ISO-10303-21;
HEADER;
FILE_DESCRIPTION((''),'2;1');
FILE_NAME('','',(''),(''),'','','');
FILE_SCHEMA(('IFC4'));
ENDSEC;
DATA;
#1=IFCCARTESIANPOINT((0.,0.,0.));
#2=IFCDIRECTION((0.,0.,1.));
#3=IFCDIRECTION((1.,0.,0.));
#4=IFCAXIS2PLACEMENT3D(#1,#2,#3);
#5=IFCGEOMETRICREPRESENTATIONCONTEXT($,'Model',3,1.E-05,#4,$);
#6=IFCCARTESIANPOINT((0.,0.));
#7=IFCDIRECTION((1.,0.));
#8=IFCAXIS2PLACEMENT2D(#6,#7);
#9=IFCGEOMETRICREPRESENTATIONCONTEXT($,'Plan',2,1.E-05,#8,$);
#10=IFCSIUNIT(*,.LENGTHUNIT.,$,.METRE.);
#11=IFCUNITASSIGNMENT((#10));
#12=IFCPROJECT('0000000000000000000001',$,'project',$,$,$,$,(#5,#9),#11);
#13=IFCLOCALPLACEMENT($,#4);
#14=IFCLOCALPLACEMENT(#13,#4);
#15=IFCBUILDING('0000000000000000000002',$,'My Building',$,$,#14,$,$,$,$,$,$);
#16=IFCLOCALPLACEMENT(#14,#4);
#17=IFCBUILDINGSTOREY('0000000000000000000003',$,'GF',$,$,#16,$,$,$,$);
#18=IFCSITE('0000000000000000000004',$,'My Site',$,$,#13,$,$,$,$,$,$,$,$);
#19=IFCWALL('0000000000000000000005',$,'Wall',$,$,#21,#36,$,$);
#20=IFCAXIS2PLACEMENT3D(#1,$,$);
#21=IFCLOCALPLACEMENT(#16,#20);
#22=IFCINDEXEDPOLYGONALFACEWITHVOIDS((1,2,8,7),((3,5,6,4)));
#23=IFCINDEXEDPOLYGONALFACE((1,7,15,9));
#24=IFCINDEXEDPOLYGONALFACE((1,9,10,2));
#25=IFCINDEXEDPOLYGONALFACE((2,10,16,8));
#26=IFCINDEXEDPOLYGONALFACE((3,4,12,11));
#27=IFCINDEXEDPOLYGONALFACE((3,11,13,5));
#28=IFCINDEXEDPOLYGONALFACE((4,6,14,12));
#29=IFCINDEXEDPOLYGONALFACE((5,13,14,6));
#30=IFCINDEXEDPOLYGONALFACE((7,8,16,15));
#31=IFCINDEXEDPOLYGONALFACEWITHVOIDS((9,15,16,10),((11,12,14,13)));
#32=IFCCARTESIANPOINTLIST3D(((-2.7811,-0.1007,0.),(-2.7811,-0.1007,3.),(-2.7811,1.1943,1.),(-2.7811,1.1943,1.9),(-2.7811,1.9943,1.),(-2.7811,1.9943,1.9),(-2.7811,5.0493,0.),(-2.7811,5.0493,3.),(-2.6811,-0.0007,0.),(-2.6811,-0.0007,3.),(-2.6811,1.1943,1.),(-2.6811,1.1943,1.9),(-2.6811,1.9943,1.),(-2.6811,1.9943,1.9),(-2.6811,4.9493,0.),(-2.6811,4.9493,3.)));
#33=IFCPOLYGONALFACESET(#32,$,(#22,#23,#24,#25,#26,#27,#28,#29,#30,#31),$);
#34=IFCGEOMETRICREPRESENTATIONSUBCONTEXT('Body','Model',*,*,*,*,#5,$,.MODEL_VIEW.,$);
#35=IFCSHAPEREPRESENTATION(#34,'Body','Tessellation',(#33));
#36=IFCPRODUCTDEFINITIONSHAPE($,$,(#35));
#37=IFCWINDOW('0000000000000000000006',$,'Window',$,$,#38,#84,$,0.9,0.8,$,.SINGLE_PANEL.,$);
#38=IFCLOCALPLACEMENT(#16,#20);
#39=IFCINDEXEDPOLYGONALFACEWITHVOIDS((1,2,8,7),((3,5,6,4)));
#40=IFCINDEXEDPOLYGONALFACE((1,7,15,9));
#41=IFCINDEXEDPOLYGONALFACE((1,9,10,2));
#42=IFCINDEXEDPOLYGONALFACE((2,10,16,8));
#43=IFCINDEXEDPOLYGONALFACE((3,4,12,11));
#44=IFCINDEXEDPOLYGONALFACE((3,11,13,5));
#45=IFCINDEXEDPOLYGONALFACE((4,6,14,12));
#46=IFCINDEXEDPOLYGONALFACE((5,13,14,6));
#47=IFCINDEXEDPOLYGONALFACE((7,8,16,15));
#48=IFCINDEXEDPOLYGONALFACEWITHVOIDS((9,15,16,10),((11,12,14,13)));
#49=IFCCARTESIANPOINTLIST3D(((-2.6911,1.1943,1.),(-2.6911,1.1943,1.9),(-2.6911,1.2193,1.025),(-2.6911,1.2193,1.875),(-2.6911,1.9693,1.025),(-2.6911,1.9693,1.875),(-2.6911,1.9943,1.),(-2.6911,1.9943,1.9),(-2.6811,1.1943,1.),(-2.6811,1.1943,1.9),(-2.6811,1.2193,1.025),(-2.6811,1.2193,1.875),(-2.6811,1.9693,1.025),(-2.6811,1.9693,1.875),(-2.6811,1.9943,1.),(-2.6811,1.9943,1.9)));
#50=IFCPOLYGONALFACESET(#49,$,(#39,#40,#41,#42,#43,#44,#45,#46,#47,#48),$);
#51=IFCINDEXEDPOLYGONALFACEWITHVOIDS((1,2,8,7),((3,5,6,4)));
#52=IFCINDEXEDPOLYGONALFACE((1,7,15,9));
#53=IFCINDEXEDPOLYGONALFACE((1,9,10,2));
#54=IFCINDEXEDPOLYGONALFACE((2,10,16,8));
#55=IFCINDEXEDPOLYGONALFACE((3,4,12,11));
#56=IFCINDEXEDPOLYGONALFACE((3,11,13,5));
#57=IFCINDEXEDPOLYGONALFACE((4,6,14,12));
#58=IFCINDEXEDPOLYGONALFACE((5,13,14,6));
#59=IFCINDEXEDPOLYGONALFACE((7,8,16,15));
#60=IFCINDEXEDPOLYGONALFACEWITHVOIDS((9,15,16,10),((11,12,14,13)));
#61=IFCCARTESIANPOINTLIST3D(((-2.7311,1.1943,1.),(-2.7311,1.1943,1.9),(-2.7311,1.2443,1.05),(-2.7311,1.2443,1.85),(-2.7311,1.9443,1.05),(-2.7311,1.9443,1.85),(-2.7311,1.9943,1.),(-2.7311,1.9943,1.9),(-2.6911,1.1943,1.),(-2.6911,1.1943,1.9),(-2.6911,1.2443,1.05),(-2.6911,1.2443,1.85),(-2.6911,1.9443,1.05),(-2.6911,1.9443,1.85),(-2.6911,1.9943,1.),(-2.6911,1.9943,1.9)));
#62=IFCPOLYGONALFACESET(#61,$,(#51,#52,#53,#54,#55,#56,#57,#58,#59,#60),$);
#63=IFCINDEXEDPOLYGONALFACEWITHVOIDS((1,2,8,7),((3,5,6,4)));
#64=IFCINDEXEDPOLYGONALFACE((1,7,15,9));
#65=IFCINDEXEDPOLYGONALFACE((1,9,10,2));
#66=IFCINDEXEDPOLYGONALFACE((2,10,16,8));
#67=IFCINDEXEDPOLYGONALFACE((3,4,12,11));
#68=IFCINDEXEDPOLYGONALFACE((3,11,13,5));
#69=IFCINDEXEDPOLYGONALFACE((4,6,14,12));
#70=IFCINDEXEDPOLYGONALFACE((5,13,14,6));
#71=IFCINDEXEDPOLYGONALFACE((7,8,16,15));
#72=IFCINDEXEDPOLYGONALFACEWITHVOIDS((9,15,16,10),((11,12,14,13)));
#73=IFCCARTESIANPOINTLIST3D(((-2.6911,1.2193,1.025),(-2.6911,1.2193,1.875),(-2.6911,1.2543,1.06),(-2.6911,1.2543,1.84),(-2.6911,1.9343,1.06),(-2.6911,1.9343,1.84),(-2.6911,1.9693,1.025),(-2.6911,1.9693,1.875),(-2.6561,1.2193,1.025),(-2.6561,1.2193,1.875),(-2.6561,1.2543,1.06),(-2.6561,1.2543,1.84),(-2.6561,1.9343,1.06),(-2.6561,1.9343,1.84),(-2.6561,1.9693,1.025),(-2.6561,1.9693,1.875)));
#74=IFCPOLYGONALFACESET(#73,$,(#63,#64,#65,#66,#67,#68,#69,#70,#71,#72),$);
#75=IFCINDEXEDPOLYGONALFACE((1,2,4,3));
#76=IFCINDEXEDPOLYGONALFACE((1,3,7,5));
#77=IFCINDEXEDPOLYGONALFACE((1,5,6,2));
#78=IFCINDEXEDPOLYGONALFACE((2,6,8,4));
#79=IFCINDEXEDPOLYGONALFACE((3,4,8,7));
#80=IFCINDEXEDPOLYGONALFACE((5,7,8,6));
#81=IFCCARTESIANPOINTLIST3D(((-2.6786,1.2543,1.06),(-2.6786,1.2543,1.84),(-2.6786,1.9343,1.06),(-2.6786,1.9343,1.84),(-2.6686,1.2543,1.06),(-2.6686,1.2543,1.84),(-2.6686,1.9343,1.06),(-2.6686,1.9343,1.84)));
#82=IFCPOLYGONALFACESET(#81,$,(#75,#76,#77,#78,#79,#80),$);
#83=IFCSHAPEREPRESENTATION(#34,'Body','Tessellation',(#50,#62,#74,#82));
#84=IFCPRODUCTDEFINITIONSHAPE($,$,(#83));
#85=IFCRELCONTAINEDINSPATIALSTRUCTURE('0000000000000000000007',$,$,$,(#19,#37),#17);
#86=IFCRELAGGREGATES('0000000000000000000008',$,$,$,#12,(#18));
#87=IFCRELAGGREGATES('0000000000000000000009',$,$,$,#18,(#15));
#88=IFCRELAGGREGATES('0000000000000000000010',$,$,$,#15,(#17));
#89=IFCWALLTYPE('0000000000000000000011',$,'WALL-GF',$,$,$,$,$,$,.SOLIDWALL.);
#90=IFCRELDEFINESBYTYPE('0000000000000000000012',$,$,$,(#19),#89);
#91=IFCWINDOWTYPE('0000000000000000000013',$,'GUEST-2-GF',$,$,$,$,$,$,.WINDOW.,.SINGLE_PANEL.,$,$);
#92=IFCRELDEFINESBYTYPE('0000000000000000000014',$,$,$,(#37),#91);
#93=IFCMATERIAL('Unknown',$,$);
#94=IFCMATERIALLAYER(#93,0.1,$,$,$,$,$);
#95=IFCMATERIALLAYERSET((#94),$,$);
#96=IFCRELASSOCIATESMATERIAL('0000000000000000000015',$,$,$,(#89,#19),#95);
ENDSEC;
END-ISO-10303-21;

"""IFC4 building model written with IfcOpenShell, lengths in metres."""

from ifc_helpers import new_model, entity, si_unit, frame, origin_with_axes, origin_2d_with_axis, place, context, subcontext, project, spatial, line, indexed_curve, outline, extrude, shape, source, transform, mapped, material, layer, layer_set, layer_usage, type_object, type_shapes, element, fill, save


model = new_model("IFC4")

# Units and contexts
model_context = context("Model", 3, precision=1e-05, world=origin_with_axes())
plan_context = context("Plan", 2, precision=1e-05, world=origin_2d_with_axis())
body_context_1 = subcontext(model_context, "Body", "Model", "MODEL_VIEW")
body_context_2 = subcontext(plan_context, "Body", "Plan", "PLAN_VIEW")
ifc_project = project(units=[si_unit("LENGTHUNIT", "METRE")], contexts=[model_context, plan_context])

# Site, building, storey
site_placement = place(None, origin_with_axes())
site = spatial("IfcSite", under=ifc_project, at=site_placement, Name="My Site")
building_placement = place(site_placement, origin_with_axes())
building = spatial("IfcBuilding", under=site, at=building_placement, Name="My Building")
storey_placement = place(building_placement, origin_with_axes())
storey = spatial("IfcBuildingStorey", under=building, at=storey_placement, Name="GF")

# Shared definitions
ifc_material_1 = material(Name="Unknown")

# Shared definitions
ifc_layer_1 = layer(ifc_material_1, 0.1)
ifc_layer_set_1 = layer_set([ifc_layer_1])
wall_type = type_object("IfcWallType", Name="WALL-GF", PredefinedType="SOLIDWALL", material=ifc_layer_set_1)

# Wall, opening, window
ifc_layer_usage_1 = layer_usage(ifc_layer_set_1, "AXIS2", "POSITIVE", 0.0)
wall_1_placement = place(storey_placement, frame((-2.7811, 5.0493, 0.0), z_axis=(0.0, 0.0, 1.0), x_axis=(0.0, -1.0, 0.0)))
wall_1 = element("IfcWall", 1, at=wall_1_placement, inside=storey, type_object=wall_type, material=ifc_layer_usage_1, Name="Wall", context=body_context_1, shape_type="SweptSolid", body=[
    extrude(outline(indexed_curve([(0.0, 0.0), (0.1, 0.1), (5.05, 0.1), (5.15, 0.0)], segments=[line(1, 2, 3, 4, 1)])), origin_with_axes(), (0.0, 0.0, 1.0), 3.0),
])
shared_shape_1 = source(origin_with_axes(), body_context_1, "Body", "SweptSolid", [
    extrude(outline(indexed_curve([(0.0, 0.0), (0.8, 0.0), (0.8, 0.9), (0.0, 0.9)], segments=[line(1, 2, 3, 4, 1)])), frame((0.0, -0.6, 0.0), z_axis=(0.0, -1.0, 0.0), x_axis=(1.0, 0.0, 0.0)), (0.0, 0.0, -1.0), 1.2),
])
opening_1_placement = place(wall_1_placement, frame((3.0549, 0.0, 1.0), z_axis=(0.0, 0.0, 1.0), x_axis=(1.0, 0.0, 0.0)))
opening_1 = element("IfcOpeningElement", 2, at=opening_1_placement, cuts=wall_1, PredefinedType="OPENING", context=body_context_1, shape_type="MappedRepresentation", body=[
    mapped(shared_shape_1, transform((0.0, 0.0, 0.0), x_axis=(1.0, 0.0, 0.0), y_axis=(0.0, 1.0, 0.0), z_axis=(0.0, 0.0, 1.0), scale=1.0)),
])
window_type_1 = type_object("IfcWindowType", Name="GUEST-2-GF", PartitioningType="SINGLE_PANEL", PredefinedType="WINDOW")
shared_shape_2 = source(origin_with_axes(), body_context_1, "Body", "SweptSolid", [
    extrude(outline(indexed_curve([(0.0, 0.0), (0.8, 0.0), (0.8, 0.9), (0.0, 0.9)], segments=[line(1, 2, 3, 4, 1)]), holes=[indexed_curve([(0.025, 0.025), (0.775, 0.025), (0.775, 0.875), (0.025, 0.875)], segments=[line(1, 2, 3, 4, 1)])]), frame((0.0, 0.09, 0.0), z_axis=(0.0, -1.0, 0.0), x_axis=(1.0, 0.0, 0.0)), (0.0, 0.0, -1.0), 0.01),
    extrude(outline(indexed_curve([(0.0, 0.0), (0.8, 0.0), (0.8, 0.9), (0.0, 0.9)], segments=[line(1, 2, 3, 4, 1)]), holes=[indexed_curve([(0.05, 0.05), (0.75, 0.05), (0.75, 0.85), (0.05, 0.85)], segments=[line(1, 2, 3, 4, 1)])]), frame((0.0, 0.05, 0.0), z_axis=(0.0, -1.0, 0.0), x_axis=(1.0, 0.0, 0.0)), (0.0, 0.0, -1.0), 0.04),
    extrude(outline(indexed_curve([(0.0, 0.0), (0.75, 0.0), (0.75, 0.85), (0.0, 0.85)], segments=[line(1, 2, 3, 4, 1)]), holes=[indexed_curve([(0.035, 0.035), (0.715, 0.035), (0.715, 0.815), (0.035, 0.815)], segments=[line(1, 2, 3, 4, 1)])]), frame((0.025, 0.09, 0.025), z_axis=(0.0, -1.0, 0.0), x_axis=(1.0, 0.0, 0.0)), (0.0, 0.0, -1.0), 0.035),
    extrude(outline(indexed_curve([(0.035, 0.035), (0.715, 0.035), (0.715, 0.815), (0.035, 0.815)], segments=[line(1, 2, 3, 4, 1)])), frame((0.025, 0.1025, 0.025), z_axis=(0.0, -1.0, 0.0), x_axis=(1.0, 0.0, 0.0)), (0.0, 0.0, -1.0), 0.01),
])
shared_shape_3 = source(origin_with_axes(), body_context_2, "Body", "Curve2D", [
    entity("IfcIndexedPolyCurve", entity("IfcCartesianPointList2D", [[0.05, 0.05], [0.75, 0.05]])),
    entity("IfcIndexedPolyCurve", entity("IfcCartesianPointList2D", [[0.0, 0.1], [0.025, 0.1], [0.025, 0.09], [0.05, 0.09], [0.05, 0.05], [0.0, 0.05]]), [entity("IfcLineIndex", [1, 2, 3, 4, 5, 6, 1])]),
    entity("IfcIndexedPolyCurve", entity("IfcCartesianPointList2D", [[0.8, 0.1], [0.775, 0.1], [0.775, 0.09], [0.75, 0.09], [0.75, 0.05], [0.8, 0.05]]), [entity("IfcLineIndex", [1, 2, 3, 4, 5, 6, 1])]),
    entity("IfcIndexedPolyCurve", entity("IfcCartesianPointList2D", [[0.025, 0.09], [0.06, 0.09], [0.06, 0.125], [0.025, 0.125]]), [entity("IfcLineIndex", [1, 2, 3, 4, 1])]),
    entity("IfcIndexedPolyCurve", entity("IfcCartesianPointList2D", [[0.775, 0.09], [0.74, 0.09], [0.74, 0.125], [0.775, 0.125]]), [entity("IfcLineIndex", [1, 2, 3, 4, 1])]),
    entity("IfcIndexedPolyCurve", entity("IfcCartesianPointList2D", [[0.06, 0.09], [0.74, 0.09]])),
    entity("IfcIndexedPolyCurve", entity("IfcCartesianPointList2D", [[0.06, 0.125], [0.74, 0.125]])),
    entity("IfcIndexedPolyCurve", entity("IfcCartesianPointList2D", [[0.06, 0.1075], [0.74, 0.1075]])),
])
type_shapes(window_type_1, [shared_shape_2, shared_shape_3])
window_1_placement = place(opening_1_placement, frame((0.0, 0.0, 0.0), z_axis=(0.0, 0.0, 1.0), x_axis=(1.0, 0.0, 0.0)))
window_1 = element("IfcWindow", 3, at=window_1_placement, inside=storey, type_object=window_type_1, Name="Window", OverallHeight=0.9, OverallWidth=0.8, PartitioningType="SINGLE_PANEL", shapes=[
    shape(body_context_1, "Body", "MappedRepresentation", [mapped(shared_shape_2, transform((0.0, 0.0, 0.0), x_axis=(1.0, 0.0, 0.0), y_axis=(0.0, 1.0, 0.0), z_axis=(0.0, 0.0, 1.0), scale=1.0))]),
    shape(body_context_2, "Body", "MappedRepresentation", [mapped(shared_shape_3, transform((0.0, 0.0, 0.0), x_axis=(1.0, 0.0, 0.0), y_axis=(0.0, 1.0, 0.0), z_axis=(0.0, 0.0, 1.0), scale=1.0))]),
])
fill(opening_1, window_1)

save(model, "model.ifc")
